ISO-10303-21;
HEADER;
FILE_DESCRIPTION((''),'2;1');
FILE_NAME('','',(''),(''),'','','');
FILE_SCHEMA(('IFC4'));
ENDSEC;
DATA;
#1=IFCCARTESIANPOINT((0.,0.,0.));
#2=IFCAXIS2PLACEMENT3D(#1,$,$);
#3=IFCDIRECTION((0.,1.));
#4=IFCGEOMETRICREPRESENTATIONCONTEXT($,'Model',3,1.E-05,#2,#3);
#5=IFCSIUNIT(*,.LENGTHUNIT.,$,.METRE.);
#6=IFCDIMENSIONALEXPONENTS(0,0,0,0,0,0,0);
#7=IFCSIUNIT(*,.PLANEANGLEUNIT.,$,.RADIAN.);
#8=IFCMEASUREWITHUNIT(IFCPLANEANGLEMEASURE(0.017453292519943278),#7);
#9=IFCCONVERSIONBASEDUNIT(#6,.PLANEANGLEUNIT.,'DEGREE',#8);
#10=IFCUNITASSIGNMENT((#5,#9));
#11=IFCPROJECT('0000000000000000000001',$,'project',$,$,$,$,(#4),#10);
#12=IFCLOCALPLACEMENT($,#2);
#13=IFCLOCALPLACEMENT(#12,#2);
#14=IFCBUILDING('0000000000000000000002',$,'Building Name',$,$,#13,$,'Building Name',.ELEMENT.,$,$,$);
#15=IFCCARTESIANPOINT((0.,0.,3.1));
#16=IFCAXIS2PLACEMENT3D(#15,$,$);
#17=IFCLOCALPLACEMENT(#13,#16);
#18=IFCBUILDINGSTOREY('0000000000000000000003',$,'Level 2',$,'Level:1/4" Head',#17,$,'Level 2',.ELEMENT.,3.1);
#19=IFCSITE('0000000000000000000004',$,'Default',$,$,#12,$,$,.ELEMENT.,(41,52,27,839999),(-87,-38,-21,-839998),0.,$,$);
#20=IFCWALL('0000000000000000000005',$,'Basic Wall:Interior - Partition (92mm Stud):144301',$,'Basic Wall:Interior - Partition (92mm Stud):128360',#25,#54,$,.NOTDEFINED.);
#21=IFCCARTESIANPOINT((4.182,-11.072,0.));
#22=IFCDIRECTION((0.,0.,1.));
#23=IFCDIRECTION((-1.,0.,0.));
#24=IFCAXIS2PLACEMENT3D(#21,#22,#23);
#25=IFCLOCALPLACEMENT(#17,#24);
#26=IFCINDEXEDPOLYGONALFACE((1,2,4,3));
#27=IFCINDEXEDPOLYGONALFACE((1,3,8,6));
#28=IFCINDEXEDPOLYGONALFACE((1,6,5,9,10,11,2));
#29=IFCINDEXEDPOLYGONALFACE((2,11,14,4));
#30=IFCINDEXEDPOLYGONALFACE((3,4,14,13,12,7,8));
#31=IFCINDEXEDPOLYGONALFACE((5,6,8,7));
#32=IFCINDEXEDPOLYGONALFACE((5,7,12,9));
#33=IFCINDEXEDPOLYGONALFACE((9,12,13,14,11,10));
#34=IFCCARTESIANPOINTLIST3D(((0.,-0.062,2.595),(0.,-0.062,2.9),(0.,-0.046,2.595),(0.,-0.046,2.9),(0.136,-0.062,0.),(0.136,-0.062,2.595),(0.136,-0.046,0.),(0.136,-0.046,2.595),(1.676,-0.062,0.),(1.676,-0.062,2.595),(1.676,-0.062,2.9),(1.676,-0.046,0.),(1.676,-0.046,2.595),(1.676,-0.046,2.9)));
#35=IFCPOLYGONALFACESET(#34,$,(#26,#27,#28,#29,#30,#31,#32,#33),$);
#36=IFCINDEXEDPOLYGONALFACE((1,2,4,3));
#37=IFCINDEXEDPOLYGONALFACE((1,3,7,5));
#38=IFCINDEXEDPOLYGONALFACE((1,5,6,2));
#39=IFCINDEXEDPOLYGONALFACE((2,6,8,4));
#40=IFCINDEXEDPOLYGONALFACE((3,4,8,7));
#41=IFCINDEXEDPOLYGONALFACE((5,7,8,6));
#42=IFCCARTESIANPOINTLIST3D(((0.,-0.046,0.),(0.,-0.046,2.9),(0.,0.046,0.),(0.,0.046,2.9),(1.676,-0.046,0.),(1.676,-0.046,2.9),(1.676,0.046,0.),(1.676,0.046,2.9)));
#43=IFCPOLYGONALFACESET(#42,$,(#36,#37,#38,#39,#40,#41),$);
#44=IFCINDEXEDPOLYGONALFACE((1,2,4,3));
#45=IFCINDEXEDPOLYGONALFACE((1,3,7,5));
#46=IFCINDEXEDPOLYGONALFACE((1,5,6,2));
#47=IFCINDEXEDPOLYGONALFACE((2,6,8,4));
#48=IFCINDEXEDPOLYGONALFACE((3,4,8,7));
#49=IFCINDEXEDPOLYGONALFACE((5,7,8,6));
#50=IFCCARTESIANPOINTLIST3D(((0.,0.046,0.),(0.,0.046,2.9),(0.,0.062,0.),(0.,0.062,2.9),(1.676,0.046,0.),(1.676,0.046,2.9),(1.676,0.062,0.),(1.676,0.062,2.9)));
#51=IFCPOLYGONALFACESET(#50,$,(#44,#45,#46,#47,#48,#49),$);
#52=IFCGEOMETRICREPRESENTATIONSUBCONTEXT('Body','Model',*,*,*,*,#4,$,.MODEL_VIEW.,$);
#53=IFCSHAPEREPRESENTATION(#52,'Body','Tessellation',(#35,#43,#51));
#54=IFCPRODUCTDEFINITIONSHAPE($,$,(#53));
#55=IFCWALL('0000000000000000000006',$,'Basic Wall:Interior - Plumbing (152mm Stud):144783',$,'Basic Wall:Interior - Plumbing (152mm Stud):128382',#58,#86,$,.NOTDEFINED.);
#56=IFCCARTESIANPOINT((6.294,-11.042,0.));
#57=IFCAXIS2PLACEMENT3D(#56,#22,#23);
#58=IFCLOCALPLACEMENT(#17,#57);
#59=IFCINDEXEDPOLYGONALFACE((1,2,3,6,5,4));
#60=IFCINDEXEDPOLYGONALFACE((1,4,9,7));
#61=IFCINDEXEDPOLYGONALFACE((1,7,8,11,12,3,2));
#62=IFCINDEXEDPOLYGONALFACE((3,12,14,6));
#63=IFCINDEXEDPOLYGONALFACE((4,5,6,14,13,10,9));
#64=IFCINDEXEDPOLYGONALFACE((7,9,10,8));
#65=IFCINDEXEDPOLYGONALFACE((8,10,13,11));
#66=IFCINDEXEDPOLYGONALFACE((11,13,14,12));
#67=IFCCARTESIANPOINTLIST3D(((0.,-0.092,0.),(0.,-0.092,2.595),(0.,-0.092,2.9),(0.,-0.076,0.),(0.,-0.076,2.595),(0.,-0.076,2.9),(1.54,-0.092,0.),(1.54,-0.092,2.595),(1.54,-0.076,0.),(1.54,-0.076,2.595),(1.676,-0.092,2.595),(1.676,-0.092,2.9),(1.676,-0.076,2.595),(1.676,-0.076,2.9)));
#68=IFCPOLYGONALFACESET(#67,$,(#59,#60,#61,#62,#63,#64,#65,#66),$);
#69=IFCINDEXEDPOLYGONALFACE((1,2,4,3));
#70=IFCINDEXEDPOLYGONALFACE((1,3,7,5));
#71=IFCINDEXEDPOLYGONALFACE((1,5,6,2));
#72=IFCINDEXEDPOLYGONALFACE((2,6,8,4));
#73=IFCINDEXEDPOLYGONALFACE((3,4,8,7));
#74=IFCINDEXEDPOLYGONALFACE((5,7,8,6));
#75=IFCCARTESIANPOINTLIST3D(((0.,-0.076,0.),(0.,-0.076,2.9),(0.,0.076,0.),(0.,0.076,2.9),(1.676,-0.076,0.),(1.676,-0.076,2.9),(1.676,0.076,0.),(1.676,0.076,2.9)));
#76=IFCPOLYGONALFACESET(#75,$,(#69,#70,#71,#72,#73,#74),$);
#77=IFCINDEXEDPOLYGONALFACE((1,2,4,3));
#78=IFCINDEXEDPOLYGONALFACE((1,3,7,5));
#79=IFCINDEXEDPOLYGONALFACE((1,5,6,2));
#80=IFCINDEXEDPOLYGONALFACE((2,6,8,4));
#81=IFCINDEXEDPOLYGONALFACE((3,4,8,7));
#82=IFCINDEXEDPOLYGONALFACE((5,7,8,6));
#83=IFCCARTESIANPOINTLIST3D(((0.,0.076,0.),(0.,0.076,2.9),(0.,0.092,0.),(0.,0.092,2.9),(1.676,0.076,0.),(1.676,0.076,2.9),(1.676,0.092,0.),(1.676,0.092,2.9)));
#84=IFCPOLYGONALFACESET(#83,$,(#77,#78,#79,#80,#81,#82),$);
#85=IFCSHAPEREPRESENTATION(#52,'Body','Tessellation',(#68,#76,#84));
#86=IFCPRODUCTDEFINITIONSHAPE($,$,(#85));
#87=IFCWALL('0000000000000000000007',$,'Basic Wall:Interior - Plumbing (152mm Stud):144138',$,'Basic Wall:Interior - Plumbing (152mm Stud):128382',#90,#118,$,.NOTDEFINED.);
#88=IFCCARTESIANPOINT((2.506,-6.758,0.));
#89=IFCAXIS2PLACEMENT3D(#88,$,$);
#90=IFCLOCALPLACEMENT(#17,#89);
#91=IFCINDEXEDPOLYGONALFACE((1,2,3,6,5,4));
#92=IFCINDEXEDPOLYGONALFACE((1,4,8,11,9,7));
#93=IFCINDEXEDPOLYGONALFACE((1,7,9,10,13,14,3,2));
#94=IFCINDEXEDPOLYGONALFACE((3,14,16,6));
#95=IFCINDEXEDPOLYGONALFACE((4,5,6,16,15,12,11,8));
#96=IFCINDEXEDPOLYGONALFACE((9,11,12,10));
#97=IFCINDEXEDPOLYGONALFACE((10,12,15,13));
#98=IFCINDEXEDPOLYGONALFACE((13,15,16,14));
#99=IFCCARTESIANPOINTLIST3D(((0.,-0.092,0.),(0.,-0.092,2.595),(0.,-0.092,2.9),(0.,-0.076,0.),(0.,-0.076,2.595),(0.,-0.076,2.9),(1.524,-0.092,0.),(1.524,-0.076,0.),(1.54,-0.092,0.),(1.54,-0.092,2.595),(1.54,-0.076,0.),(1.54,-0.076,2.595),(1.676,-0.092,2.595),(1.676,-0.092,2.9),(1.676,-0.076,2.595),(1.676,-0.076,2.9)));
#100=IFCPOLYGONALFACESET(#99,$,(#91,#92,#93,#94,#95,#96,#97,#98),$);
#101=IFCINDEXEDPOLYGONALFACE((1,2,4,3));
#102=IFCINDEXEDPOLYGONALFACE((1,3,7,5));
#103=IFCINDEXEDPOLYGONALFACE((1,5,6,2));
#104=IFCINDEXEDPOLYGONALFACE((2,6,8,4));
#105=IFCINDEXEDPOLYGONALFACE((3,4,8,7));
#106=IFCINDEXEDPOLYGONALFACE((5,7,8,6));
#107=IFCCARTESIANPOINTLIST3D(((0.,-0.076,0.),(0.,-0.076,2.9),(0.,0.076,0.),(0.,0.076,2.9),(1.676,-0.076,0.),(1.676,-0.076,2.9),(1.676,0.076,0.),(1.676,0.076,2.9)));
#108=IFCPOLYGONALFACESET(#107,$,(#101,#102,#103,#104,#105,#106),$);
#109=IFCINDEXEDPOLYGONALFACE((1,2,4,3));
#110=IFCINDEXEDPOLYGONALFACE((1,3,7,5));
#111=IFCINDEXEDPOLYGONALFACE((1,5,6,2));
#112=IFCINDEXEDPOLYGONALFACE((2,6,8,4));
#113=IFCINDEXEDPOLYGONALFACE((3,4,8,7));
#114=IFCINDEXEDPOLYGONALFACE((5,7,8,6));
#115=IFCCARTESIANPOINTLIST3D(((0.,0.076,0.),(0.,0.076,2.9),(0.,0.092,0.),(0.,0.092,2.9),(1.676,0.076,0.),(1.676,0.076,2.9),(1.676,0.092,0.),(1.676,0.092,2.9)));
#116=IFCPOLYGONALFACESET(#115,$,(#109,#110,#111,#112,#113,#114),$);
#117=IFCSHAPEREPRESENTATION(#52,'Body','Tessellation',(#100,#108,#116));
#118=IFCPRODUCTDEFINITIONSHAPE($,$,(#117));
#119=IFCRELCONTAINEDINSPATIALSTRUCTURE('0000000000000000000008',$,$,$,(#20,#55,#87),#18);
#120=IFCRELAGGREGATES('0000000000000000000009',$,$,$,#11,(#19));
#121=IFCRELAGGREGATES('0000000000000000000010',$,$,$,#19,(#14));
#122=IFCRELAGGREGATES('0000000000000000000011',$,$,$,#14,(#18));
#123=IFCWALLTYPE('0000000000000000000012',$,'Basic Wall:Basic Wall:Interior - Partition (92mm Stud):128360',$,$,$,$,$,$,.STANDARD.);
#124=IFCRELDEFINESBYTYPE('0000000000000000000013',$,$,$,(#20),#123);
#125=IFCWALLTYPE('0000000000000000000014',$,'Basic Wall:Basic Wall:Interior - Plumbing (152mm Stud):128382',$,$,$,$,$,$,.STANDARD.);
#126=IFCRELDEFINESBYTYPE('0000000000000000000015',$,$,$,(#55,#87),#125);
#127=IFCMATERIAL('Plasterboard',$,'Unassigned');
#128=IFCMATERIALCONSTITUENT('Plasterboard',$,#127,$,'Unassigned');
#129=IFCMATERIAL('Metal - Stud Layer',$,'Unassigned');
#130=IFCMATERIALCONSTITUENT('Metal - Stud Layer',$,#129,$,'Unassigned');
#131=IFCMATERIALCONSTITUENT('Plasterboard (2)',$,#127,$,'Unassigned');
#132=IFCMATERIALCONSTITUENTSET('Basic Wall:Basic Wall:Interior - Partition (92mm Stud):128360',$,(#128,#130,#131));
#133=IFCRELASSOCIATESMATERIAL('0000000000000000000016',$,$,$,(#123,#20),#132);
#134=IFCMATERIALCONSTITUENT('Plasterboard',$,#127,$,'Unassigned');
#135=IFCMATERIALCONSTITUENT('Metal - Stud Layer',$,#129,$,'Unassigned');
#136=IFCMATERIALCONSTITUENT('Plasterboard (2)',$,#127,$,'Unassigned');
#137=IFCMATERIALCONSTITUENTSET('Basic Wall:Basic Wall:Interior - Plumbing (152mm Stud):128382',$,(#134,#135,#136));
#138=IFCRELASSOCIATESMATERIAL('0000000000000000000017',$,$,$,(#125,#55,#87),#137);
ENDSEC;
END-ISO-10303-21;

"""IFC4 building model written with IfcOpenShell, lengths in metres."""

from ifc_helpers import new_model, entity, si_unit, converted_unit, direction, frame, origin, place, context, subcontext, project, spatial, indexed_curve, outline, extrude, material, constituent, constituent_set, type_object, element, save


model = new_model("IFC4")

# Units and contexts
model_context = context("Model", 3, precision=1e-05, world=origin(), true_north=direction((0.0, 1.0)))
body_context = subcontext(model_context, "Body", "Model", "MODEL_VIEW")
ifc_project = project(units=[si_unit("LENGTHUNIT", "METRE"), converted_unit("PLANEANGLEUNIT", "DEGREE", entity("IfcPlaneAngleMeasure", 0.017453292519943278), si_unit("PLANEANGLEUNIT", "RADIAN"), dimensions=[0, 0, 0, 0, 0, 0, 0])], contexts=[model_context])

# Site, building, storey
site_placement = place(None, origin())
site = spatial("IfcSite", under=ifc_project, at=site_placement, Name="Default", CompositionType="ELEMENT", RefLatitude=(41, 52, 27, 839999), RefLongitude=(-87, -38, -21, -839998), RefElevation=0.0)
building_placement = place(site_placement, origin())
building = spatial("IfcBuilding", under=site, at=building_placement, Name="Building Name", LongName="Building Name", CompositionType="ELEMENT")
storey_placement = place(building_placement, frame((0.0, 0.0, 3.1)))
storey = spatial("IfcBuildingStorey", under=building, at=storey_placement, Name="Level 2", ObjectType="Level:1/4\" Head", LongName="Level 2", CompositionType="ELEMENT", Elevation=3.1)

# Shared definitions
ifc_material_1 = material(Name="Plasterboard", Category="Unassigned")
ifc_constituent_1 = constituent(ifc_material_1, Name="Plasterboard", Category="Unassigned")
ifc_material_2 = material(Name="Metal - Stud Layer", Category="Unassigned")
ifc_constituent_2 = constituent(ifc_material_2, Name="Metal - Stud Layer", Category="Unassigned")
ifc_constituent_3 = constituent(ifc_material_1, Name="Plasterboard (2)", Category="Unassigned")
ifc_constituent_set_1 = constituent_set(constituents=[ifc_constituent_1, ifc_constituent_2, ifc_constituent_3], Name="Basic Wall:Basic Wall:Interior - Partition (92mm Stud):128360")
wall_type_1 = type_object("IfcWallType", Name="Basic Wall:Basic Wall:Interior - Partition (92mm Stud):128360", PredefinedType="STANDARD", material=ifc_constituent_set_1)

# Wall
wall_1_placement = place(storey_placement, frame((4.182, -11.072, 0.0), z_axis=(0.0, 0.0, 1.0), x_axis=(-1.0, 0.0, 0.0)))
element("IfcWall", 1, at=wall_1_placement, inside=storey, type_object=wall_type_1, material=ifc_constituent_set_1, Name="Basic Wall:Interior - Partition (92mm Stud):144301", ObjectType="Basic Wall:Interior - Partition (92mm Stud):128360", PredefinedType="NOTDEFINED", context=body_context, shape_type="SweptSolid", body=[
    extrude(outline(indexed_curve([(-1.9407, -0.9189), (0.6543, -0.9189), (0.9593, -0.9189), (0.9593, 0.7571), (0.6543, 0.7571), (0.6543, 0.6211), (-1.9407, 0.6211), (-1.9407, -0.9189)], self_intersect=False)), frame((0.7571, -0.046, 1.9407), z_axis=(0.0, -1.0, 0.0), x_axis=(0.0, 0.0, 1.0)), (0.0, 0.0, 1.0), 0.016),
    extrude(outline(indexed_curve([(-0.046, -0.838), (0.046, -0.838), (0.046, 0.838), (-0.046, 0.838), (-0.046, -0.838)], self_intersect=False)), frame((0.838, 0.0, 0.0), z_axis=(0.0, 0.0, 1.0), x_axis=(0.0, 1.0, 0.0)), (0.0, 0.0, 1.0), 2.9),
    extrude(outline(indexed_curve([(-0.008, -0.838), (0.008, -0.838), (0.008, 0.838), (-0.008, 0.838), (-0.008, -0.838)], self_intersect=False)), frame((0.838, 0.054, 0.0), z_axis=(0.0, 0.0, 1.0), x_axis=(0.0, 1.0, 0.0)), (0.0, 0.0, 1.0), 2.9),
])

# Walls
ifc_constituent_4 = constituent(ifc_material_1, Name="Plasterboard", Category="Unassigned")
ifc_constituent_5 = constituent(ifc_material_2, Name="Metal - Stud Layer", Category="Unassigned")
ifc_constituent_6 = constituent(ifc_material_1, Name="Plasterboard (2)", Category="Unassigned")
ifc_constituent_set_2 = constituent_set(constituents=[ifc_constituent_4, ifc_constituent_5, ifc_constituent_6], Name="Basic Wall:Basic Wall:Interior - Plumbing (152mm Stud):128382")
wall_type_2 = type_object("IfcWallType", Name="Basic Wall:Basic Wall:Interior - Plumbing (152mm Stud):128382", PredefinedType="STANDARD", material=ifc_constituent_set_2)
wall_2_placement = place(storey_placement, frame((6.294, -11.042, 0.0), z_axis=(0.0, 0.0, 1.0), x_axis=(-1.0, 0.0, 0.0)))
element("IfcWall", 2, at=wall_2_placement, inside=storey, type_object=wall_type_2, material=ifc_constituent_set_2, Name="Basic Wall:Interior - Plumbing (152mm Stud):144783", ObjectType="Basic Wall:Interior - Plumbing (152mm Stud):128382", PredefinedType="NOTDEFINED", context=body_context, shape_type="SweptSolid", body=[
    extrude(outline(indexed_curve([(-1.9407, 0.6211), (-1.9407, -0.9189), (0.6543, -0.9189), (0.9593, -0.9189), (0.9593, 0.7571), (0.6543, 0.7571), (0.6543, 0.6211), (-1.9407, 0.6211)], self_intersect=False)), frame((0.9189, -0.076, 1.9407), z_axis=(0.0, 1.0, 0.0), x_axis=(0.0, 0.0, 1.0)), (0.0, 0.0, -1.0), 0.016),
    extrude(outline(indexed_curve([(-0.076, -0.838), (0.076, -0.838), (0.076, 0.838), (-0.076, 0.838), (-0.076, -0.838)], self_intersect=False)), frame((0.838, 0.0, 0.0), z_axis=(0.0, 0.0, 1.0), x_axis=(0.0, 1.0, 0.0)), (0.0, 0.0, 1.0), 2.9),
    extrude(outline(indexed_curve([(-0.008, -0.838), (0.008, -0.838), (0.008, 0.838), (-0.008, 0.838), (-0.008, -0.838)], self_intersect=False)), frame((0.838, 0.084, 0.0), z_axis=(0.0, 0.0, 1.0), x_axis=(0.0, 1.0, 0.0)), (0.0, 0.0, 1.0), 2.9),
])
wall_3_placement = place(storey_placement, frame((2.506, -6.758, 0.0)))
element("IfcWall", 3, at=wall_3_placement, inside=storey, type_object=wall_type_2, material=ifc_constituent_set_2, Name="Basic Wall:Interior - Plumbing (152mm Stud):144138", ObjectType="Basic Wall:Interior - Plumbing (152mm Stud):128382", PredefinedType="NOTDEFINED", context=body_context, shape_type="SweptSolid", body=[
    extrude(outline(indexed_curve([(-1.6981, -0.9945), (0.8969, -0.9945), (1.2019, -0.9945), (1.2019, 0.6815), (0.8969, 0.6815), (0.8969, 0.5455), (-1.6981, 0.5455), (-1.6981, 0.5295), (-1.6981, -0.9945)], self_intersect=False)), frame((0.9945, -0.092, 1.6981), z_axis=(0.0, 1.0, 0.0), x_axis=(0.0, 0.0, 1.0)), (0.0, 0.0, 1.0), 0.016),
    extrude(outline(indexed_curve([(-0.076, -0.838), (0.076, -0.838), (0.076, 0.838), (-0.076, 0.838), (-0.076, -0.838)], self_intersect=False)), frame((0.838, 0.0, 0.0), z_axis=(0.0, 0.0, 1.0), x_axis=(0.0, 1.0, 0.0)), (0.0, 0.0, 1.0), 2.9),
    extrude(outline(indexed_curve([(-0.008, -0.838), (0.008, -0.838), (0.008, 0.838), (-0.008, 0.838), (-0.008, -0.838)], self_intersect=False)), frame((0.838, 0.084, 0.0), z_axis=(0.0, 0.0, 1.0), x_axis=(0.0, 1.0, 0.0)), (0.0, 0.0, 1.0), 2.9),
])

save(model, "model.ifc")
